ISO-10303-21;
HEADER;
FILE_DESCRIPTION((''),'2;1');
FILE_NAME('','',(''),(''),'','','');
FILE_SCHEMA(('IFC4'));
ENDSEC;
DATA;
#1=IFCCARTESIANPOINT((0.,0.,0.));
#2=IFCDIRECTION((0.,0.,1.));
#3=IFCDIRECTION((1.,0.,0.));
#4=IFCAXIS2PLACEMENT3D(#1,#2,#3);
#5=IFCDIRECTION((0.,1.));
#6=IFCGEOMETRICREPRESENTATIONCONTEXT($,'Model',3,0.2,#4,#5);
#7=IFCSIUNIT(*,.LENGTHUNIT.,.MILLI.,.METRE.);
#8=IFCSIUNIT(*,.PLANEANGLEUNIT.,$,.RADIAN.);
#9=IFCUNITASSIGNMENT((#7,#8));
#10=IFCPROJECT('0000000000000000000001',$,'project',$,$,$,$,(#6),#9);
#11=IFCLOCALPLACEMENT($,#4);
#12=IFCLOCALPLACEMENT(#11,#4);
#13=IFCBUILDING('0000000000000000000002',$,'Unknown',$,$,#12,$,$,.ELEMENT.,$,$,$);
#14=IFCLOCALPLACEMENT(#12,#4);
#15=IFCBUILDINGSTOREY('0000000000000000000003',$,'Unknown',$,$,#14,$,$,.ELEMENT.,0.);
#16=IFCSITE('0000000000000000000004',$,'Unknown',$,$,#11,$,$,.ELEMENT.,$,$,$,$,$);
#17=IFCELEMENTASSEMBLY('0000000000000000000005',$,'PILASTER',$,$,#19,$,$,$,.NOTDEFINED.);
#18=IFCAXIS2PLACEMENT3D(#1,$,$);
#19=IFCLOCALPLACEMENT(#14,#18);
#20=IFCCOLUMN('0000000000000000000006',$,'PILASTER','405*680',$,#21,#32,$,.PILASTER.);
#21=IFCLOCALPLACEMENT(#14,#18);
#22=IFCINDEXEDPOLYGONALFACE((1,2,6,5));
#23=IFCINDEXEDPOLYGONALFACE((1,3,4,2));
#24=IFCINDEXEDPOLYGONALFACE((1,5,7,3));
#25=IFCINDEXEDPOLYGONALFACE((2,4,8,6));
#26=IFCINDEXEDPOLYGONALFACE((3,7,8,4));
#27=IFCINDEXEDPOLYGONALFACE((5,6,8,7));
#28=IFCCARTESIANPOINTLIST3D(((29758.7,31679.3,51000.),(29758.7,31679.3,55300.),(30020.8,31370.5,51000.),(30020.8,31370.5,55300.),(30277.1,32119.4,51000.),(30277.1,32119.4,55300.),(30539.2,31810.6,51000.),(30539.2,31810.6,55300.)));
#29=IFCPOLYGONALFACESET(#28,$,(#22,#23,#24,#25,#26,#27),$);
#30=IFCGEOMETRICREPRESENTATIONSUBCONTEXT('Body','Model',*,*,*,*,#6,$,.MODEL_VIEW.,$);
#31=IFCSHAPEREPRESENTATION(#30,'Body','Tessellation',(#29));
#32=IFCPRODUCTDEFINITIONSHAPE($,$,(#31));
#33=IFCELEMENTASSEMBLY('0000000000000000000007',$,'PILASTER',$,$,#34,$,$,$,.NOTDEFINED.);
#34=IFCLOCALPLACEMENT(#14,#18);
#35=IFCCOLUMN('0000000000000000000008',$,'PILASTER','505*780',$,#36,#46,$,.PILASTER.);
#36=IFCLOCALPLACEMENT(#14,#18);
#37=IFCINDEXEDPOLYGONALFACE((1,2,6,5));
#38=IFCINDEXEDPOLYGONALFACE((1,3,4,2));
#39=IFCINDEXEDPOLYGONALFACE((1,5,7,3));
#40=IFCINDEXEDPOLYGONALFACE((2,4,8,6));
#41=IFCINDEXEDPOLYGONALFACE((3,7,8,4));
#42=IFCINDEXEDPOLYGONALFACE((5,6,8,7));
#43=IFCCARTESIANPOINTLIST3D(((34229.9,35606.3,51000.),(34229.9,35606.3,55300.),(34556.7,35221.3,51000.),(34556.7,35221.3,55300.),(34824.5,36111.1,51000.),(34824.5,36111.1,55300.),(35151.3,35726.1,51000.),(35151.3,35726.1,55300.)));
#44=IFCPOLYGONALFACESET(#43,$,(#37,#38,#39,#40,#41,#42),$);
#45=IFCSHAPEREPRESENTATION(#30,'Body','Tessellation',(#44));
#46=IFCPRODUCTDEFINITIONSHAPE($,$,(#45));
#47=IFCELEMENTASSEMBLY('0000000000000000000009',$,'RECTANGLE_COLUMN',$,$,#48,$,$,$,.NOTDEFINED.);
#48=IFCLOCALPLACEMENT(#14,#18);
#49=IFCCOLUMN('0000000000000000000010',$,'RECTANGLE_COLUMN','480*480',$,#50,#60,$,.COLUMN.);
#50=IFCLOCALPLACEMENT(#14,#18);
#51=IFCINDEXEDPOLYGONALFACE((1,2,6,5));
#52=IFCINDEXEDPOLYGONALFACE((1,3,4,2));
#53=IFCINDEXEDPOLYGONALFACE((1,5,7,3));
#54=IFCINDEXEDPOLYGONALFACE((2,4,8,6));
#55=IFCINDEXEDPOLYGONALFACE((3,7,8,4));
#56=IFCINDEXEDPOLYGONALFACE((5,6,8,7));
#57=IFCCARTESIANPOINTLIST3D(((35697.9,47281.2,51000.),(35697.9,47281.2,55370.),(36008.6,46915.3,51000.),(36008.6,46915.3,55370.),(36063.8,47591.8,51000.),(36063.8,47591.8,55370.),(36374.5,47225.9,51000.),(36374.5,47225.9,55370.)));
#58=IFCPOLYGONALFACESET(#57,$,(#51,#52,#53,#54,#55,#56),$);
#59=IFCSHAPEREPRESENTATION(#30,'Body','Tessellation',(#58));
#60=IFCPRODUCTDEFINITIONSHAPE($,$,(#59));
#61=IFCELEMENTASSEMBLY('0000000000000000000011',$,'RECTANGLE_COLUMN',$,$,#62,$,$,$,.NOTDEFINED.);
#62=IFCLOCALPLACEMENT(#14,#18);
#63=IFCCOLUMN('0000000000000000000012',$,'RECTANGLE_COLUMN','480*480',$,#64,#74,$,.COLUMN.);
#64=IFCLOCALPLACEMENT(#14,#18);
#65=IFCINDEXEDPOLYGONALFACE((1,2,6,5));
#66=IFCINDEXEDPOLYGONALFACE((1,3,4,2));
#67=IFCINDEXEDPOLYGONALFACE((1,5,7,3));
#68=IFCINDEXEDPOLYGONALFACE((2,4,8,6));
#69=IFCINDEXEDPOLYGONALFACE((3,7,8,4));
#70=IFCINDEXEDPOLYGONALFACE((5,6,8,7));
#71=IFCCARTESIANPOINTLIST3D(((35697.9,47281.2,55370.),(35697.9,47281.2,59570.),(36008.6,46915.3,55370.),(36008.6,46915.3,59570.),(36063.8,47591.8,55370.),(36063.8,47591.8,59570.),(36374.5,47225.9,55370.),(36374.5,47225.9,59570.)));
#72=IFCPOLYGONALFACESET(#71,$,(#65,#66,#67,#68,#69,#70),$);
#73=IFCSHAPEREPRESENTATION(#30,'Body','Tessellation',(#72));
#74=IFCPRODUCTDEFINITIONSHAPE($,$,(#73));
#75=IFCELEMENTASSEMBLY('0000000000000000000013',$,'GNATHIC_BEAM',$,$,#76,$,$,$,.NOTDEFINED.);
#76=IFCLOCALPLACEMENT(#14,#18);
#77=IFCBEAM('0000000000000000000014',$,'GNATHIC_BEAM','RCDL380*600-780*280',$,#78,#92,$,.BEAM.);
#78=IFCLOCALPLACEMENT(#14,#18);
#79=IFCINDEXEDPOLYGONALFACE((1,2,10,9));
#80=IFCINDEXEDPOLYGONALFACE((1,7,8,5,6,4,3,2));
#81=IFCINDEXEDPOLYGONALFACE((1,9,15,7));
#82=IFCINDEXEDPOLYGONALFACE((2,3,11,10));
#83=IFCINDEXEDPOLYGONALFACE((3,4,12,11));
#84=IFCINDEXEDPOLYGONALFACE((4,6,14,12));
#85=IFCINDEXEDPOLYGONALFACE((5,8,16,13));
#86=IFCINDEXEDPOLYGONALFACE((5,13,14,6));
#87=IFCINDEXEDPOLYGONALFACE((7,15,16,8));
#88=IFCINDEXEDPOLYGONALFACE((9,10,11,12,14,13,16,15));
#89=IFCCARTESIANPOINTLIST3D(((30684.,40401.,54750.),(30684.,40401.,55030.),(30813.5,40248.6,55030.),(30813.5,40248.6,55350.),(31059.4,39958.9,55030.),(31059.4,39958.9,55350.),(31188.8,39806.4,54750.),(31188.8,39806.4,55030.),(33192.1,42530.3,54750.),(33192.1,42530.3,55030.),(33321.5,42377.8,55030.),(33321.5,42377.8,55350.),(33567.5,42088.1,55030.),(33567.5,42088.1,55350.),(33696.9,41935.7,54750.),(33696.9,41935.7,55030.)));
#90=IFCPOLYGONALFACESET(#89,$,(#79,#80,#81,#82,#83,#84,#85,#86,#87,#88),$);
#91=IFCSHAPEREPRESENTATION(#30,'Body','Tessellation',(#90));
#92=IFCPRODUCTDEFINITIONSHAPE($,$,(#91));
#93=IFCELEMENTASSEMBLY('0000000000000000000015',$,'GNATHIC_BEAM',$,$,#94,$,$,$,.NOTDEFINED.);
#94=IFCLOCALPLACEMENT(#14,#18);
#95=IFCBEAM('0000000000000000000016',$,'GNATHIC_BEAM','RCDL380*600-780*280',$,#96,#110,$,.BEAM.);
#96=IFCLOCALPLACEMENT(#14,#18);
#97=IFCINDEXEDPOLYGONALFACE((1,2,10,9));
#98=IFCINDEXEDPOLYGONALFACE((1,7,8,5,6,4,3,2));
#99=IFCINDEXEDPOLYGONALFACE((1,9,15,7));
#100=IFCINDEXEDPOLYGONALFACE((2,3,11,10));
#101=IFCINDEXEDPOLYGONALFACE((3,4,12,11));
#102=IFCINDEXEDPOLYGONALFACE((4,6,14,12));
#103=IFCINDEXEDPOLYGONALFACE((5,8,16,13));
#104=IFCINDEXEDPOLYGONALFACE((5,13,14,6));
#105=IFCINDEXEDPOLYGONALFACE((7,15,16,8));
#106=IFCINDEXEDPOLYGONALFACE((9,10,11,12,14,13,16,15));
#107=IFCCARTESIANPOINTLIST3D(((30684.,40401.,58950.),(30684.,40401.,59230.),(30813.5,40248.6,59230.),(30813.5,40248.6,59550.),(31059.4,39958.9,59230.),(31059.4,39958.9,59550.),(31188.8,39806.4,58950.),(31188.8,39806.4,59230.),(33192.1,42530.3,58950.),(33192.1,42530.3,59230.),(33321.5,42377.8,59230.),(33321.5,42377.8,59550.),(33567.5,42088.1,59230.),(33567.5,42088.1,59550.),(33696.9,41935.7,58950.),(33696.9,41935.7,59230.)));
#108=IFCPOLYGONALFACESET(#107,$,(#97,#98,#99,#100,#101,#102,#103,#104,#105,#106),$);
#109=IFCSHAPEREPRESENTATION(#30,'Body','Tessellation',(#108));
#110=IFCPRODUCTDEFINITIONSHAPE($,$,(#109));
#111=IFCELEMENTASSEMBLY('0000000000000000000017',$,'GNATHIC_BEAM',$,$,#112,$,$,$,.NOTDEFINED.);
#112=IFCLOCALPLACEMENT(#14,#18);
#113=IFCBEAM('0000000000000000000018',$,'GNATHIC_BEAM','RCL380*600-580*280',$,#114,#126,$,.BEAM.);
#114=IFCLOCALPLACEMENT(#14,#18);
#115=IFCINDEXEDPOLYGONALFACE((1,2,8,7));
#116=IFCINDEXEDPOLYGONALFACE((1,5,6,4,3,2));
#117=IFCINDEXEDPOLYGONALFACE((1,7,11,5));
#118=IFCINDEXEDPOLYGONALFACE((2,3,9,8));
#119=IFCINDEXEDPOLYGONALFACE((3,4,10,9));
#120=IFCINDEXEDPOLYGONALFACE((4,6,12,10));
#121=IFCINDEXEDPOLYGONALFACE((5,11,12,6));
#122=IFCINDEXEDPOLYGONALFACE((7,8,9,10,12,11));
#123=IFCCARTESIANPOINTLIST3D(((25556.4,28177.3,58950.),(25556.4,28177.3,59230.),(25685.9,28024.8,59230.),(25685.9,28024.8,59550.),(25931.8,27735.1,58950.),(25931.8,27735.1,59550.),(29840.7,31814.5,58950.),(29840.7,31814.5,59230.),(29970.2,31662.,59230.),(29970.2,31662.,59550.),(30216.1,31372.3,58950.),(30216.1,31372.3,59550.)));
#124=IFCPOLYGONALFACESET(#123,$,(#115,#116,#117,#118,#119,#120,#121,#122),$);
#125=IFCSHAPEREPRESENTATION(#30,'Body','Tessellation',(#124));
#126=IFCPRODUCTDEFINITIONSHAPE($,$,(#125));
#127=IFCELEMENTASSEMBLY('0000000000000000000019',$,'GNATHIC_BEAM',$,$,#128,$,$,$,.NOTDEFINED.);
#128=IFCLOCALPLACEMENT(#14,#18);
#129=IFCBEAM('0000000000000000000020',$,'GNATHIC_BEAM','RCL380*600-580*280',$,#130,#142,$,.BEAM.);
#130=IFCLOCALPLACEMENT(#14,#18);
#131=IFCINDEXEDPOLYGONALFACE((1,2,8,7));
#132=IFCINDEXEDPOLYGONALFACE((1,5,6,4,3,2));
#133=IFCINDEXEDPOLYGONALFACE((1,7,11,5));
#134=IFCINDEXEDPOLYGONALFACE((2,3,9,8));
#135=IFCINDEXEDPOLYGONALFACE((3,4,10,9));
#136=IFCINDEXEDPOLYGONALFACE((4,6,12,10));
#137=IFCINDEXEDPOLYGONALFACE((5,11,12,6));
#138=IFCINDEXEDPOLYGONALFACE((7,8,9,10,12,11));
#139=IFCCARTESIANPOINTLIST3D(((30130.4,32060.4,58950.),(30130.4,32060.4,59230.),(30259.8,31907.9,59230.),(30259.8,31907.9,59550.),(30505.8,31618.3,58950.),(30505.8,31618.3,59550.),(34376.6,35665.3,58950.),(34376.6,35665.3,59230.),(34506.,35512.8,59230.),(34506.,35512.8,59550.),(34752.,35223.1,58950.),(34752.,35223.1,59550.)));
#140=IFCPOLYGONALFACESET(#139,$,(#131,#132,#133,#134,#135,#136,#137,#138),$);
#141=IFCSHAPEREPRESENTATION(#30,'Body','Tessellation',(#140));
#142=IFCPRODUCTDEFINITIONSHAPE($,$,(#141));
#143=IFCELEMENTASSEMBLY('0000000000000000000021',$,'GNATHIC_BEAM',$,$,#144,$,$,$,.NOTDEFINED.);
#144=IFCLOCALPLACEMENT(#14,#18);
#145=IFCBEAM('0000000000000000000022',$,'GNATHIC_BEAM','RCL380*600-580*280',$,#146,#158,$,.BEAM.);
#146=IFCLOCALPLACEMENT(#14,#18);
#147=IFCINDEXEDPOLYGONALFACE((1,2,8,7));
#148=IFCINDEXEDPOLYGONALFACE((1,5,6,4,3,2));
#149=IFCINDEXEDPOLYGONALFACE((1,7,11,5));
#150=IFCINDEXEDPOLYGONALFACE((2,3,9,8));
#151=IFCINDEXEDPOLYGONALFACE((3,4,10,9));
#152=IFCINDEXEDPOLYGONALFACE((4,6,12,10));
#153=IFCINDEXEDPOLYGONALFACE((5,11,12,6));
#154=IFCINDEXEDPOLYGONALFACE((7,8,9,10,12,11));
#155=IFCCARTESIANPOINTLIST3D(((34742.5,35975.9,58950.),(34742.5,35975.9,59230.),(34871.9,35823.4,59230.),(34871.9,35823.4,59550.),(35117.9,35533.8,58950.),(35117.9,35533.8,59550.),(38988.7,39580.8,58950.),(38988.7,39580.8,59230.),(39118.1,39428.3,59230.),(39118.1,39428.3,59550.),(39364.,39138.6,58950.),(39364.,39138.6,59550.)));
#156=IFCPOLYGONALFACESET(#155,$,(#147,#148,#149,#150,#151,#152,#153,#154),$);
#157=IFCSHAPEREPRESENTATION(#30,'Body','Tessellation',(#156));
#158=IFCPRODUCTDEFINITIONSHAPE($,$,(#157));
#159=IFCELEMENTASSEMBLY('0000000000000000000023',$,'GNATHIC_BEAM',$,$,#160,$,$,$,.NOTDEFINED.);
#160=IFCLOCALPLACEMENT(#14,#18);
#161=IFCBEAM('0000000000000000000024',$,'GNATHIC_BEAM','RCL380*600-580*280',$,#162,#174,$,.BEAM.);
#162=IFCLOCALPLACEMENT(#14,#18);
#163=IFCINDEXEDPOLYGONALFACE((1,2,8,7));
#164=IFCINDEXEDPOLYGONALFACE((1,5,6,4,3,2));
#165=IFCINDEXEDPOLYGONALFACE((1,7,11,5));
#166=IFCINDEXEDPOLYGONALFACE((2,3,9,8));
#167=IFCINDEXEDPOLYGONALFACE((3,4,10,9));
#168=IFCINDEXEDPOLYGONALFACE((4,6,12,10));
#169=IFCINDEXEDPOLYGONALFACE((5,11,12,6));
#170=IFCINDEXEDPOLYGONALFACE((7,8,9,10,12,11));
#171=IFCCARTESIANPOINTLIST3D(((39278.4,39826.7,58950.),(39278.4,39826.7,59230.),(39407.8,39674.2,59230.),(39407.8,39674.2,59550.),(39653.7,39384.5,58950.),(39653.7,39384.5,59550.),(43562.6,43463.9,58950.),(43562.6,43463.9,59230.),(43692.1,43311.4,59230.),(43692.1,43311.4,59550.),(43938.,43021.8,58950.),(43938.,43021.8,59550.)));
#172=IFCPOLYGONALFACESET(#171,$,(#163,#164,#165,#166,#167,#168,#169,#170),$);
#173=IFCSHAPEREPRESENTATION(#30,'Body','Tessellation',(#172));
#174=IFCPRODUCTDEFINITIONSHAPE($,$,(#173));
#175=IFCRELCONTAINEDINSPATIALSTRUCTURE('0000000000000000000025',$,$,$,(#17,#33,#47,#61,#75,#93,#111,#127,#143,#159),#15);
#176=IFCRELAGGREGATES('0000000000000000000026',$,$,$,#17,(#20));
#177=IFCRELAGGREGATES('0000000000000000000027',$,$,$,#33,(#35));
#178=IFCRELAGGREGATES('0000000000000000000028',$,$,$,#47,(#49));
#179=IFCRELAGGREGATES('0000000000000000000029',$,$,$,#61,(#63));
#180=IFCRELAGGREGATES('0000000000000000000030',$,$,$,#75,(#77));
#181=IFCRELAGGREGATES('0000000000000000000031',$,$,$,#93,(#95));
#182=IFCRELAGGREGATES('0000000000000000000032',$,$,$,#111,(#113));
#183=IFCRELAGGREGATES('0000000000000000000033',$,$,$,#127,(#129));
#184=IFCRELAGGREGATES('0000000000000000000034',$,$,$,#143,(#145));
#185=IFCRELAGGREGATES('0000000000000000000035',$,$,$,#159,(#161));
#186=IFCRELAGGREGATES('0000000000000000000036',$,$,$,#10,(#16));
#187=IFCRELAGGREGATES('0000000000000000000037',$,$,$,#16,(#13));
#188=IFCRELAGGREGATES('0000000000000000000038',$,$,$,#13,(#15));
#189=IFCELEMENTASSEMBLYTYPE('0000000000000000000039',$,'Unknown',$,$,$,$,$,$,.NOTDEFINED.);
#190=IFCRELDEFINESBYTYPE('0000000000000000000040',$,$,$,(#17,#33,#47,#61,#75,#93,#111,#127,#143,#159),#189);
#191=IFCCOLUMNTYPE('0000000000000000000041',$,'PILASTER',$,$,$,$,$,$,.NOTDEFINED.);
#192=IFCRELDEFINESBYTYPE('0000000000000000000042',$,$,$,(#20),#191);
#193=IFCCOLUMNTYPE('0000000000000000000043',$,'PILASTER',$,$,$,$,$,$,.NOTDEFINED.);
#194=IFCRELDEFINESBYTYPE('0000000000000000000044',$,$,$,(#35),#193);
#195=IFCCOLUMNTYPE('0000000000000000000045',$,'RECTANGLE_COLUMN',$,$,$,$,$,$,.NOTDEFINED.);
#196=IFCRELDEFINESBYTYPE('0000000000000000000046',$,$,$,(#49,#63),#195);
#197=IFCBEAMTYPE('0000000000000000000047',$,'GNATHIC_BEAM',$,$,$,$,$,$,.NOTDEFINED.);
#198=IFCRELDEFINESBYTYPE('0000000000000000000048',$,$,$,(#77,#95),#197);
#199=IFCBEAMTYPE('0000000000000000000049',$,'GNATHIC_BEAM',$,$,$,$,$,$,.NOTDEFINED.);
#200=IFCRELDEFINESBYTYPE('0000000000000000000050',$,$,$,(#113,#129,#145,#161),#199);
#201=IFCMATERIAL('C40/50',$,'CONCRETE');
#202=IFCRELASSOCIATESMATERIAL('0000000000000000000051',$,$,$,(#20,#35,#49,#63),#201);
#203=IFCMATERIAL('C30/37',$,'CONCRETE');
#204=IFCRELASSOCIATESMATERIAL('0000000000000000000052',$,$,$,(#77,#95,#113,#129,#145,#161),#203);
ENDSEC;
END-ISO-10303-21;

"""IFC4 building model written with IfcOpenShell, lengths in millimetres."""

from ifc_helpers import new_model, si_unit, direction, frame, origin_with_axes, origin_2d_with_axis, place, context, subcontext, project, spatial, polyline, rectangle, outline, extrude, material, material_profile, profile_set, profile_usage, type_object, element, aggregate, save


model = new_model("IFC4")

# Units and contexts
model_context = context("Model", 3, precision=0.2, world=origin_with_axes(), true_north=direction((0.0, 1.0)))
body_context = subcontext(model_context, "Body", "Model", "MODEL_VIEW")
ifc_project = project(units=[si_unit("LENGTHUNIT", "METRE", prefix="MILLI"), si_unit("PLANEANGLEUNIT", "RADIAN")], contexts=[model_context])

# Site, building, storey
site_placement = place(None, origin_with_axes())
site = spatial("IfcSite", under=ifc_project, at=site_placement, Name="Unknown", CompositionType="ELEMENT")
building_placement = place(site_placement, origin_with_axes())
building = spatial("IfcBuilding", under=site, at=building_placement, Name="Unknown", CompositionType="ELEMENT")
storey_placement = place(building_placement, origin_with_axes())
storey = spatial("IfcBuildingStorey", under=building, at=storey_placement, Name="Unknown", CompositionType="ELEMENT", Elevation=0.0)

# Shared definitions
element_assembly_type = type_object("IfcElementAssemblyType", Name="Unknown", PredefinedType="NOTDEFINED")
ifc_material_1 = material(Name="C40/50", Category="CONCRETE")

# Element assemblies, columns
ifc_material_profile_1 = material_profile(ifc_material_1, rectangle(XDim=680.0, YDim=405.0, at=origin_2d_with_axis()), Name="405*680")
ifc_profile_set_1 = profile_set([ifc_material_profile_1])
ifc_profile_usage_1 = profile_usage(ifc_profile_set_1, cardinal=6)
column_type_1 = type_object("IfcColumnType", Name="PILASTER")
assembly_1_placement = place(storey_placement, frame((30149.0, 31745.0, 51000.0), z_axis=(-0.762329, -0.64719, 0.0), x_axis=(0.0, 0.0, 1.0)))
assembly_1 = element("IfcElementAssembly", 1, at=assembly_1_placement, inside=storey, type_object=element_assembly_type, Name="PILASTER", PredefinedType="NOTDEFINED")
column_1_placement = place(assembly_1_placement, origin_with_axes())
column_1 = element("IfcColumn", 2, at=column_1_placement, type_object=column_type_1, material=ifc_profile_usage_1, Name="PILASTER", Description="405*680", PredefinedType="PILASTER", context=body_context, shape_type="SolidModel", body=[
    extrude(rectangle(XDim=680.0, YDim=405.0, at=origin_2d_with_axis()), frame((0.0, 0.0, 0.0), z_axis=(-1.0, 0.0, 0.0), x_axis=(0.0, 0.0, 1.0)), (0.0, 0.0, -1.0), 4300.0),
])
aggregate(assembly_1, [column_1])
assembly_2_placement = place(storey_placement, frame((34690.6, 35666.2, 51000.0), z_axis=(-0.762329, -0.64719, 0.0), x_axis=(0.0, 0.0, 1.0)))
assembly_2 = element("IfcElementAssembly", 3, at=assembly_2_placement, inside=storey, type_object=element_assembly_type, Name="PILASTER", PredefinedType="NOTDEFINED")
ifc_material_profile_2 = material_profile(ifc_material_1, rectangle(XDim=780.0, YDim=505.0, at=origin_2d_with_axis()), Name="505*780")
ifc_profile_set_2 = profile_set([ifc_material_profile_2])
ifc_profile_usage_2 = profile_usage(ifc_profile_set_2, cardinal=6)
column_type_2 = type_object("IfcColumnType", Name="PILASTER")
column_2_placement = place(assembly_2_placement, origin_with_axes())
column_2 = element("IfcColumn", 4, at=column_2_placement, type_object=column_type_2, material=ifc_profile_usage_2, Name="PILASTER", Description="505*780", PredefinedType="PILASTER", context=body_context, shape_type="SolidModel", body=[
    extrude(rectangle(XDim=780.0, YDim=505.0, at=origin_2d_with_axis()), frame((0.0, 0.0, 0.0), z_axis=(-1.0, 0.0, 0.0), x_axis=(0.0, 0.0, 1.0)), (0.0, 0.0, -1.0), 4300.0),
])
aggregate(assembly_2, [column_2])
assembly_3_placement = place(storey_placement, frame((36036.2, 47253.6, 51000.0), z_axis=(-0.762329, -0.64719, 0.0), x_axis=(0.0, 0.0, 1.0)))
assembly_3 = element("IfcElementAssembly", 5, at=assembly_3_placement, inside=storey, type_object=element_assembly_type, Name="RECTANGLE_COLUMN", PredefinedType="NOTDEFINED")
ifc_material_profile_3 = material_profile(ifc_material_1, rectangle(XDim=480.0, YDim=480.0, at=origin_2d_with_axis()), Name="480*480")
ifc_profile_set_3 = profile_set([ifc_material_profile_3])
ifc_profile_usage_3 = profile_usage(ifc_profile_set_3, cardinal=5)
column_type_3 = type_object("IfcColumnType", Name="RECTANGLE_COLUMN")
column_3_placement = place(assembly_3_placement, origin_with_axes())
column_3 = element("IfcColumn", 6, at=column_3_placement, type_object=column_type_3, material=ifc_profile_usage_3, Name="RECTANGLE_COLUMN", Description="480*480", PredefinedType="COLUMN", context=body_context, shape_type="SolidModel", body=[
    extrude(rectangle(XDim=480.0, YDim=480.0, at=origin_2d_with_axis()), frame((0.0, 0.0, 0.0), z_axis=(-1.0, 0.0, 0.0), x_axis=(0.0, 0.0, 1.0)), (0.0, 0.0, -1.0), 4370.0),
])
aggregate(assembly_3, [column_3])
assembly_4_placement = place(storey_placement, frame((36036.2, 47253.6, 55370.0), z_axis=(-0.762329, -0.64719, 0.0), x_axis=(0.0, 0.0, 1.0)))
assembly_4 = element("IfcElementAssembly", 7, at=assembly_4_placement, inside=storey, type_object=element_assembly_type, Name="RECTANGLE_COLUMN", PredefinedType="NOTDEFINED")
column_4_placement = place(assembly_4_placement, origin_with_axes())
column_4 = element("IfcColumn", 8, at=column_4_placement, type_object=column_type_3, material=ifc_profile_usage_3, Name="RECTANGLE_COLUMN", Description="480*480", PredefinedType="COLUMN", context=body_context, shape_type="SolidModel", body=[
    extrude(rectangle(XDim=480.0, YDim=480.0, at=origin_2d_with_axis()), frame((0.0, 0.0, 0.0), z_axis=(-1.0, 0.0, 0.0), x_axis=(0.0, 0.0, 1.0)), (0.0, 0.0, -1.0), 4200.0),
])
aggregate(assembly_4, [column_4])

# Element assemblies, beams
assembly_5_placement = place(storey_placement, frame((30936.4, 40103.7, 55050.0), z_axis=(0.64719, -0.762329, 0.0), x_axis=(0.762329, 0.64719, 0.0)))
assembly_5 = element("IfcElementAssembly", 9, at=assembly_5_placement, inside=storey, type_object=element_assembly_type, Name="GNATHIC_BEAM", PredefinedType="NOTDEFINED")
ifc_material_2 = material(Name="C30/37", Category="CONCRETE")
ifc_material_profile_4 = material_profile(ifc_material_2, outline(polyline([(-390.0, -300.0), (390.0, -300.0), (390.0, -20.0), (190.0, -20.0), (190.0, 300.0), (-190.0, 300.0), (-190.0, -20.0), (-390.0, -20.0), (-390.0, -300.0)])), Name="RCDL380*600-780*280")
ifc_profile_set_4 = profile_set([ifc_material_profile_4])
ifc_profile_usage_4 = profile_usage(ifc_profile_set_4, cardinal=2)
beam_type_1 = type_object("IfcBeamType", Name="GNATHIC_BEAM")
beam_1_placement = place(assembly_5_placement, origin_with_axes())
beam_1 = element("IfcBeam", 10, at=beam_1_placement, type_object=beam_type_1, material=ifc_profile_usage_4, Name="GNATHIC_BEAM", Description="RCDL380*600-780*280", PredefinedType="BEAM", context=body_context, shape_type="SolidModel", body=[
    extrude(outline(polyline([(-390.0, -300.0), (390.0, -300.0), (390.0, -20.0), (190.0, -20.0), (190.0, 300.0), (-190.0, 300.0), (-190.0, -20.0), (-390.0, -20.0), (-390.0, -300.0)])), frame((0.0, 0.0, 0.0), z_axis=(-1.0, 0.0, 0.0), x_axis=(0.0, 0.0, 1.0)), (0.0, 0.0, -1.0), 3290.0),
])
aggregate(assembly_5, [beam_1])
assembly_6_placement = place(storey_placement, frame((30936.4, 40103.7, 59250.0), z_axis=(0.64719, -0.762329, 0.0), x_axis=(0.762329, 0.64719, 0.0)))
assembly_6 = element("IfcElementAssembly", 11, at=assembly_6_placement, inside=storey, type_object=element_assembly_type, Name="GNATHIC_BEAM", PredefinedType="NOTDEFINED")
beam_2_placement = place(assembly_6_placement, origin_with_axes())
beam_2 = element("IfcBeam", 12, at=beam_2_placement, type_object=beam_type_1, material=ifc_profile_usage_4, Name="GNATHIC_BEAM", Description="RCDL380*600-780*280", PredefinedType="BEAM", context=body_context, shape_type="SolidModel", body=[
    extrude(outline(polyline([(-390.0, -300.0), (390.0, -300.0), (390.0, -20.0), (190.0, -20.0), (190.0, 300.0), (-190.0, 300.0), (-190.0, -20.0), (-390.0, -20.0), (-390.0, -300.0)])), frame((0.0, 0.0, 0.0), z_axis=(-1.0, 0.0, 0.0), x_axis=(0.0, 0.0, 1.0)), (0.0, 0.0, -1.0), 3290.0),
])
aggregate(assembly_6, [beam_2])
assembly_7_placement = place(storey_placement, frame((30093.1, 31517.2, 59250.0), z_axis=(-0.64719, 0.762329, 0.0), x_axis=(-0.762329, -0.64719, 0.0)))
assembly_7 = element("IfcElementAssembly", 13, at=assembly_7_placement, inside=storey, type_object=element_assembly_type, Name="GNATHIC_BEAM", PredefinedType="NOTDEFINED")
ifc_material_profile_5 = material_profile(ifc_material_2, outline(polyline([(-190.0, -300.0), (390.0, -300.0), (390.0, -20.0), (190.0, -20.0), (190.0, 300.0), (-190.0, 300.0), (-190.0, -300.0)])), Name="RCL380*600-580*280")
ifc_profile_set_5 = profile_set([ifc_material_profile_5])
ifc_profile_usage_5 = profile_usage(ifc_profile_set_5, cardinal=2)
beam_type_2 = type_object("IfcBeamType", Name="GNATHIC_BEAM")
beam_3_placement = place(assembly_7_placement, origin_with_axes())
beam_3 = element("IfcBeam", 14, at=beam_3_placement, type_object=beam_type_2, material=ifc_profile_usage_5, Name="GNATHIC_BEAM", Description="RCL380*600-580*280", PredefinedType="BEAM", context=body_context, shape_type="SolidModel", body=[
    extrude(outline(polyline([(-190.0, -300.0), (390.0, -300.0), (390.0, -20.0), (190.0, -20.0), (190.0, 300.0), (-190.0, 300.0), (-190.0, -300.0)])), frame((0.0, 0.0, 0.0), z_axis=(-1.0, 0.0, 0.0), x_axis=(0.0, 0.0, 1.0)), (0.0, 0.0, -1.0), 5620.0),
])
aggregate(assembly_7, [beam_3])
assembly_8_placement = place(storey_placement, frame((34629.0, 35368.0, 59250.0), z_axis=(-0.64719, 0.762329, 0.0), x_axis=(-0.762329, -0.64719, 0.0)))
assembly_8 = element("IfcElementAssembly", 15, at=assembly_8_placement, inside=storey, type_object=element_assembly_type, Name="GNATHIC_BEAM", PredefinedType="NOTDEFINED")
beam_4_placement = place(assembly_8_placement, origin_with_axes())
beam_4 = element("IfcBeam", 16, at=beam_4_placement, type_object=beam_type_2, material=ifc_profile_usage_5, Name="GNATHIC_BEAM", Description="RCL380*600-580*280", PredefinedType="BEAM", context=body_context, shape_type="SolidModel", body=[
    extrude(outline(polyline([(-190.0, -300.0), (390.0, -300.0), (390.0, -20.0), (190.0, -20.0), (190.0, 300.0), (-190.0, 300.0), (-190.0, -300.0)])), frame((0.0, 0.0, 0.0), z_axis=(-1.0, 0.0, 0.0), x_axis=(0.0, 0.0, 1.0)), (0.0, 0.0, -1.0), 5570.0),
])
aggregate(assembly_8, [beam_4])
assembly_9_placement = place(storey_placement, frame((39241.1, 39283.5, 59250.0), z_axis=(-0.64719, 0.762329, 0.0), x_axis=(-0.762329, -0.64719, 0.0)))
assembly_9 = element("IfcElementAssembly", 17, at=assembly_9_placement, inside=storey, type_object=element_assembly_type, Name="GNATHIC_BEAM", PredefinedType="NOTDEFINED")
beam_5_placement = place(assembly_9_placement, origin_with_axes())
beam_5 = element("IfcBeam", 18, at=beam_5_placement, type_object=beam_type_2, material=ifc_profile_usage_5, Name="GNATHIC_BEAM", Description="RCL380*600-580*280", PredefinedType="BEAM", context=body_context, shape_type="SolidModel", body=[
    extrude(outline(polyline([(-190.0, -300.0), (390.0, -300.0), (390.0, -20.0), (190.0, -20.0), (190.0, 300.0), (-190.0, 300.0), (-190.0, -300.0)])), frame((0.0, 0.0, 0.0), z_axis=(-1.0, 0.0, 0.0), x_axis=(0.0, 0.0, 1.0)), (0.0, 0.0, -1.0), 5570.0),
])
aggregate(assembly_9, [beam_5])
assembly_10_placement = place(storey_placement, frame((43815.0, 43166.6, 59250.0), z_axis=(-0.64719, 0.762329, 0.0), x_axis=(-0.762329, -0.64719, 0.0)))
assembly_10 = element("IfcElementAssembly", 19, at=assembly_10_placement, inside=storey, type_object=element_assembly_type, Name="GNATHIC_BEAM", PredefinedType="NOTDEFINED")
beam_6_placement = place(assembly_10_placement, origin_with_axes())
beam_6 = element("IfcBeam", 20, at=beam_6_placement, type_object=beam_type_2, material=ifc_profile_usage_5, Name="GNATHIC_BEAM", Description="RCL380*600-580*280", PredefinedType="BEAM", context=body_context, shape_type="SolidModel", body=[
    extrude(outline(polyline([(-190.0, -300.0), (390.0, -300.0), (390.0, -20.0), (190.0, -20.0), (190.0, 300.0), (-190.0, 300.0), (-190.0, -300.0)])), frame((0.0, 0.0, 0.0), z_axis=(-1.0, 0.0, 0.0), x_axis=(0.0, 0.0, 1.0)), (0.0, 0.0, -1.0), 5620.0),
])
aggregate(assembly_10, [beam_6])

save(model, "model.ifc")
